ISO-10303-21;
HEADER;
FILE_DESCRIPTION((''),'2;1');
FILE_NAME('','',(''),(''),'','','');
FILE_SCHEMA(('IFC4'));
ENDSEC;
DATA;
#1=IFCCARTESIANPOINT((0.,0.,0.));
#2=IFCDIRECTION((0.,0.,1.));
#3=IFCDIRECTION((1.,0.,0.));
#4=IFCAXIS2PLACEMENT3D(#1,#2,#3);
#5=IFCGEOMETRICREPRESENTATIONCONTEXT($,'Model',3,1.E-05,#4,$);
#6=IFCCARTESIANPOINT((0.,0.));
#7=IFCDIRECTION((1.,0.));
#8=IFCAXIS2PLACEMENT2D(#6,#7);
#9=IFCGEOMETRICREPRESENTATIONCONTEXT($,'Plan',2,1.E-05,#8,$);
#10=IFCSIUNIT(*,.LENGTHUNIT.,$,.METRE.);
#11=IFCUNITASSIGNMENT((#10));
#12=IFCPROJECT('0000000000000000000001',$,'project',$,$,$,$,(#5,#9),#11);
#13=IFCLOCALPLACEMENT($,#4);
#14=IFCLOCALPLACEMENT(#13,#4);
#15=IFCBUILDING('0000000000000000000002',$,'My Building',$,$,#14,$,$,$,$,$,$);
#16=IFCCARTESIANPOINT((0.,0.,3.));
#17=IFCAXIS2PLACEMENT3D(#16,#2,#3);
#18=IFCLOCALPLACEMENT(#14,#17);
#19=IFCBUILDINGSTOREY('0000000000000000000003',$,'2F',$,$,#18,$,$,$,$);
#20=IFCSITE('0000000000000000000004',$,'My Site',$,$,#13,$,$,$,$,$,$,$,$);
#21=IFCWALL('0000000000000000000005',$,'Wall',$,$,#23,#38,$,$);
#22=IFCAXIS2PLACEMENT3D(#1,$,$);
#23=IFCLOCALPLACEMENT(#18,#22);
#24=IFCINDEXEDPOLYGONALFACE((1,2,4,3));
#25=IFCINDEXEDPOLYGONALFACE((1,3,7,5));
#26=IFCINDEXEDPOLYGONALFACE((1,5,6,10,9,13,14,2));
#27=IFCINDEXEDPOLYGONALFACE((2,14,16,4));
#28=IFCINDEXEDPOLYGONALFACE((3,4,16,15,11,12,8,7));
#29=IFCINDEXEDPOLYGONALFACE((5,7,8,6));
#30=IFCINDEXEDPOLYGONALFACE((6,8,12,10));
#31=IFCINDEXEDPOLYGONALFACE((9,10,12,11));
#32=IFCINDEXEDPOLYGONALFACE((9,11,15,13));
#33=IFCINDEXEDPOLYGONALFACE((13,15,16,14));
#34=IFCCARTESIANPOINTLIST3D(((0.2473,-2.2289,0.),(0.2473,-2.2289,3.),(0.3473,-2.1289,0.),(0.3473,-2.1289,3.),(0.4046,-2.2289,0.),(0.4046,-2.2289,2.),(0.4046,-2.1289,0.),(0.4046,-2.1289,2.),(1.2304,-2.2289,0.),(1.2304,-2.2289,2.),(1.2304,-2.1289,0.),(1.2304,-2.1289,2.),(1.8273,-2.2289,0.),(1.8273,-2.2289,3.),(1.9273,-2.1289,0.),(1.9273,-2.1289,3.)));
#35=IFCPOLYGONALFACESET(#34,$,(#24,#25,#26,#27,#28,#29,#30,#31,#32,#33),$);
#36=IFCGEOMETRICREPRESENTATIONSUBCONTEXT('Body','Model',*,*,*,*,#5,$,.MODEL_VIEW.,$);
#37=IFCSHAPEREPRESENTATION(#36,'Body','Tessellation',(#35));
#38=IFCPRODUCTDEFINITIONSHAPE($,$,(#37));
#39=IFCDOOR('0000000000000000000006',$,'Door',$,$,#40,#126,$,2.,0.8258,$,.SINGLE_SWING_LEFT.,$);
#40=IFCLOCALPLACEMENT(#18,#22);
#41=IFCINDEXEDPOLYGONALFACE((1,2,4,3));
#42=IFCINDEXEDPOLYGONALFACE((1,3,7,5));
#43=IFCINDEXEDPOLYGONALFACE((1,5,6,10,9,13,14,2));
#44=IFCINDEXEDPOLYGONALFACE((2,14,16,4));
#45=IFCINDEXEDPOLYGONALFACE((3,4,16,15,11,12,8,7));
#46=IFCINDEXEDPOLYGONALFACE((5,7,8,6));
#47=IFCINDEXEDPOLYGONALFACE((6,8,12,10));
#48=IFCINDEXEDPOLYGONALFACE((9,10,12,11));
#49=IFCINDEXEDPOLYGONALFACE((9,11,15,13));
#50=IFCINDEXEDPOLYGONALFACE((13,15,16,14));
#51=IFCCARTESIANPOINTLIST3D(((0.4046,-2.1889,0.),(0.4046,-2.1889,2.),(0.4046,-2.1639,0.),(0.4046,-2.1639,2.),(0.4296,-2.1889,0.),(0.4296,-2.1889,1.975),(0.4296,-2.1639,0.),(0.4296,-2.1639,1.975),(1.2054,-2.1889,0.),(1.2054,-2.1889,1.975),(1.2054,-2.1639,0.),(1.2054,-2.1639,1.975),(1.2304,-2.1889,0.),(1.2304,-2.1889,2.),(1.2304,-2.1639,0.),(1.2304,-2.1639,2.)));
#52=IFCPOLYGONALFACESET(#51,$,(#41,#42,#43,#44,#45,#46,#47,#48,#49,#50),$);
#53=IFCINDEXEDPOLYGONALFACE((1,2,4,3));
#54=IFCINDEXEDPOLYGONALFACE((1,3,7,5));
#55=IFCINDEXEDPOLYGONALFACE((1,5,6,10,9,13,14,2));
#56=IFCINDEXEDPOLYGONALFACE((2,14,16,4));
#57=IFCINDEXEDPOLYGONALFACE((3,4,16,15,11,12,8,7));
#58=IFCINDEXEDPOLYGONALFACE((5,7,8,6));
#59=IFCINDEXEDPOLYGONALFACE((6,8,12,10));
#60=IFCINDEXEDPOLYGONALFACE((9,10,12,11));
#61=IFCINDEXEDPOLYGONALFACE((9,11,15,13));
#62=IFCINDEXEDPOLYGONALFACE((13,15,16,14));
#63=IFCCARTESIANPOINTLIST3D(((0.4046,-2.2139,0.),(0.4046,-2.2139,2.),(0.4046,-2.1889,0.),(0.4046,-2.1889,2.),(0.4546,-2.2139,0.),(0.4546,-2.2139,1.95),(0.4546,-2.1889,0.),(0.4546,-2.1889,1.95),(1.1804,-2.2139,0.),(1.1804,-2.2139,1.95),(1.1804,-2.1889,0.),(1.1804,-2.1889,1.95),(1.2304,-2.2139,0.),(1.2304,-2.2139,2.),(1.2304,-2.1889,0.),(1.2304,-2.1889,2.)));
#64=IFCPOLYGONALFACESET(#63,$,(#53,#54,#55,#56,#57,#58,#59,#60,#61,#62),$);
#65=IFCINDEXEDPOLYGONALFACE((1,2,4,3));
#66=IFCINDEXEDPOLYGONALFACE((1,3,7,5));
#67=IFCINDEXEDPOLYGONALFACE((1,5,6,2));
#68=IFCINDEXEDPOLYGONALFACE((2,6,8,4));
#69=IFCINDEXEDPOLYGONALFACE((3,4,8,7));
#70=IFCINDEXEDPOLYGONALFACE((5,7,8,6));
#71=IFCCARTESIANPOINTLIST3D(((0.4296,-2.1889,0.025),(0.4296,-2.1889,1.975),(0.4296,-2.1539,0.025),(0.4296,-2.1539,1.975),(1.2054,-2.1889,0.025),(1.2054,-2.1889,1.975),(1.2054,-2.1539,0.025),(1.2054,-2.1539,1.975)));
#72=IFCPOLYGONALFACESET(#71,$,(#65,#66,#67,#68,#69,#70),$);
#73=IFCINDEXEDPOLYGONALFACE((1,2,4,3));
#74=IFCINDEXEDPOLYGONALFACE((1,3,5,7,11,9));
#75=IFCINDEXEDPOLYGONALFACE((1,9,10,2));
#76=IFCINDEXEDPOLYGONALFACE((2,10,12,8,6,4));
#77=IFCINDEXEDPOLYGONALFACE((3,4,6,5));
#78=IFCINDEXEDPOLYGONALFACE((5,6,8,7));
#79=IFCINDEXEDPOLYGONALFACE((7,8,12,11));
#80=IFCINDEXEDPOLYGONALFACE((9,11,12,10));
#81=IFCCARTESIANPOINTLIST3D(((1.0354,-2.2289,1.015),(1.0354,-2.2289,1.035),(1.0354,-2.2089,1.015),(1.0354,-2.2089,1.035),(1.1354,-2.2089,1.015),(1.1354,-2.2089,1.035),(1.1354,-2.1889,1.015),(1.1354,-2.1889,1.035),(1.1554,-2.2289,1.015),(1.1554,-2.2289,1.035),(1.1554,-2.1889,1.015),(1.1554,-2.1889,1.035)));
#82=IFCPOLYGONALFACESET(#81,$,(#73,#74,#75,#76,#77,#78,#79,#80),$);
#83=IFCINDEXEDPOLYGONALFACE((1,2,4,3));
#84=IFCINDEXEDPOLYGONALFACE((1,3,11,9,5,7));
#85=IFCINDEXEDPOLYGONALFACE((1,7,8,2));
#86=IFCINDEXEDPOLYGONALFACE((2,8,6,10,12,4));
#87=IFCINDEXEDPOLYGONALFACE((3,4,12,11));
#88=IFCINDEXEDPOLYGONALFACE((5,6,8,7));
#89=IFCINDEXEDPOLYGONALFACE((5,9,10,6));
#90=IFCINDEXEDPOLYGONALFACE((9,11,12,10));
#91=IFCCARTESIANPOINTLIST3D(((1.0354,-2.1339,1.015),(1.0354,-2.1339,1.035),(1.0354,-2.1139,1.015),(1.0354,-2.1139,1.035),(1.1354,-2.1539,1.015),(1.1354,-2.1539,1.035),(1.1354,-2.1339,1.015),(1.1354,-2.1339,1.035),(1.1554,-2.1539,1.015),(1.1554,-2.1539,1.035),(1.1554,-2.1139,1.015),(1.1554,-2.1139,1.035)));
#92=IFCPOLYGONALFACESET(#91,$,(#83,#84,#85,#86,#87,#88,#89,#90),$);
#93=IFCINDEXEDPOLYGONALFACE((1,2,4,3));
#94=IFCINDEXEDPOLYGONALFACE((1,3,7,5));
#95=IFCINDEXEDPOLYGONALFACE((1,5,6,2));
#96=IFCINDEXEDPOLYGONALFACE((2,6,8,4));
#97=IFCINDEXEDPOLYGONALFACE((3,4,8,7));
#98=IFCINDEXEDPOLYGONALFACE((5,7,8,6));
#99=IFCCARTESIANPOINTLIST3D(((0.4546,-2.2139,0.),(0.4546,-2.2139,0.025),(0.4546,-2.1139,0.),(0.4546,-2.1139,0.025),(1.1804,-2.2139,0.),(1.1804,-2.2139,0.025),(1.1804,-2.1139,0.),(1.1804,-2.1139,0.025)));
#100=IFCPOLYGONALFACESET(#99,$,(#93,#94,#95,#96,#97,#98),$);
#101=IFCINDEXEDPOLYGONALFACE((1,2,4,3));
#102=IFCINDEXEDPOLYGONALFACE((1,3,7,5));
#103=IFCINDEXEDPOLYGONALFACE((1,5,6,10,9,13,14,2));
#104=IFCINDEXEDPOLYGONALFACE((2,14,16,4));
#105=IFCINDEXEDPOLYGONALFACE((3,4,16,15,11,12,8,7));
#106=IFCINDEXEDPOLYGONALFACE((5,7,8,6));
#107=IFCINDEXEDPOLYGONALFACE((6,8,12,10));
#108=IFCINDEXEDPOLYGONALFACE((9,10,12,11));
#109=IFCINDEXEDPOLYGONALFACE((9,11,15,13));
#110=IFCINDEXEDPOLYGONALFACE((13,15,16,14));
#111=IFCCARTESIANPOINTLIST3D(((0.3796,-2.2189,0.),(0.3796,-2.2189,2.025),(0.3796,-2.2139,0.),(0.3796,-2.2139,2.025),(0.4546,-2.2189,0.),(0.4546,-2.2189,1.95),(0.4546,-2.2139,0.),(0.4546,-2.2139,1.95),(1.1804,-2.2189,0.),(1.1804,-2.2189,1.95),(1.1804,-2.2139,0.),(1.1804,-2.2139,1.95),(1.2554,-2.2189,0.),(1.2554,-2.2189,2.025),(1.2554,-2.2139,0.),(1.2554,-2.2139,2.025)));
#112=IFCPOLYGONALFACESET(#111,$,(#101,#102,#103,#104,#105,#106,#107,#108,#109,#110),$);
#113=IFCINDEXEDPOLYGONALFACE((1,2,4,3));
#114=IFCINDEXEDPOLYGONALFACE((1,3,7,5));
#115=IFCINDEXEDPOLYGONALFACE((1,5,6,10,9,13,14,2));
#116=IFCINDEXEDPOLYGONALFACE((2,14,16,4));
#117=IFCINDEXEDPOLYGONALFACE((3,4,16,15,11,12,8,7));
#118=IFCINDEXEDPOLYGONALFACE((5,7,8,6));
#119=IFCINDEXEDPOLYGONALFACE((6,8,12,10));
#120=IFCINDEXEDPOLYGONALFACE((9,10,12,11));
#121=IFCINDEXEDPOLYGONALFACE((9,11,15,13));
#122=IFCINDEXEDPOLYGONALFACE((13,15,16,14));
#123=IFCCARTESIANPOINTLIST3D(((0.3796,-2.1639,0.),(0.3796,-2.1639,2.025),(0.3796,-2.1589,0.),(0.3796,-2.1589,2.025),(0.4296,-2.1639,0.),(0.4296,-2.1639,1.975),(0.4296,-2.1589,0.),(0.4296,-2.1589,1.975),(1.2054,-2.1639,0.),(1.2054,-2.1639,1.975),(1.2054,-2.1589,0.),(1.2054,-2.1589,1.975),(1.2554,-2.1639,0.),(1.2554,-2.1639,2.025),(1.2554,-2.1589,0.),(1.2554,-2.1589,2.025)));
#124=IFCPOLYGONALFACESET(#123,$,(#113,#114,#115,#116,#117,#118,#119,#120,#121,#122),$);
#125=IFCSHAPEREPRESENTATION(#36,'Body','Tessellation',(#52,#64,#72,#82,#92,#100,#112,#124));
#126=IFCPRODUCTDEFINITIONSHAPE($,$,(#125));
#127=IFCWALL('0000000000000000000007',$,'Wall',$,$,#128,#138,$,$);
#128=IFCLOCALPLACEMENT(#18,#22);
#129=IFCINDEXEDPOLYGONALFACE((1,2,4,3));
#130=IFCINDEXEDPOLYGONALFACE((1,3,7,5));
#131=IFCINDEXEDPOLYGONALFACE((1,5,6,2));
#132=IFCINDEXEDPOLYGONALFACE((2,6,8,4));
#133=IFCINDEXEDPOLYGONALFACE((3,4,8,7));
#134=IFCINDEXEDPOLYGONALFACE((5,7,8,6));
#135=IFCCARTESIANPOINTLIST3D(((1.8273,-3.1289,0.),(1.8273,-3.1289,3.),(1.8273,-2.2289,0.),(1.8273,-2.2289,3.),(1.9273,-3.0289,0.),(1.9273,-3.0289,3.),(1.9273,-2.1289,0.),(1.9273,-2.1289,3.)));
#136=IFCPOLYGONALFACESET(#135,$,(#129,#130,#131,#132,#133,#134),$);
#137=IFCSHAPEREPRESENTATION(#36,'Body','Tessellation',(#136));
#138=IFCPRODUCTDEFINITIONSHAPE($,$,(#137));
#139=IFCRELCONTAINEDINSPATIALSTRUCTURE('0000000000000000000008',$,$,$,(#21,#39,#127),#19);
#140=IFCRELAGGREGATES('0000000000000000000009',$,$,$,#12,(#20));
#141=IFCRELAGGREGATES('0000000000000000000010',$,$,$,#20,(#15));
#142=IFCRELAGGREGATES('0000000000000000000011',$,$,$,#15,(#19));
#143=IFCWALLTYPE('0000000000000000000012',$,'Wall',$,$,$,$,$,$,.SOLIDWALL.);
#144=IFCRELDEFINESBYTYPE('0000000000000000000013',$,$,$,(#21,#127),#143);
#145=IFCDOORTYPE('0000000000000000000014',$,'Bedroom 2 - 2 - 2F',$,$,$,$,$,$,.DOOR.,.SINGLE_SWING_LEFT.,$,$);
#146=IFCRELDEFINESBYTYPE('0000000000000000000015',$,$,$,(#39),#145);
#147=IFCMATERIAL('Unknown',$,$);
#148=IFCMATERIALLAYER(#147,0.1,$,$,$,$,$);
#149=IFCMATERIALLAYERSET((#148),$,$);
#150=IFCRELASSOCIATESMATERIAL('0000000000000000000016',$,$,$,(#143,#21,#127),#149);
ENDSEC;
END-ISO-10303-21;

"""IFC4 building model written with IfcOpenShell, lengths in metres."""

from ifc_helpers import new_model, entity, si_unit, frame, origin_with_axes, origin_2d_with_axis, place, context, subcontext, project, spatial, line, indexed_curve, outline, extrude, shape, source, transform, mapped, material, layer, layer_set, layer_usage, type_object, type_shapes, element, fill, save


model = new_model("IFC4")

# Units and contexts
model_context = context("Model", 3, precision=1e-05, world=origin_with_axes())
plan_context = context("Plan", 2, precision=1e-05, world=origin_2d_with_axis())
body_context_1 = subcontext(model_context, "Body", "Model", "MODEL_VIEW")
body_context_2 = subcontext(plan_context, "Body", "Plan", "PLAN_VIEW")
ifc_project = project(units=[si_unit("LENGTHUNIT", "METRE")], contexts=[model_context, plan_context])

# Site, building, storey
site_placement = place(None, origin_with_axes())
site = spatial("IfcSite", under=ifc_project, at=site_placement, Name="My Site")
building_placement = place(site_placement, origin_with_axes())
building = spatial("IfcBuilding", under=site, at=building_placement, Name="My Building")
storey_placement = place(building_placement, frame((0.0, 0.0, 3.0), z_axis=(0.0, 0.0, 1.0), x_axis=(1.0, 0.0, 0.0)))
storey = spatial("IfcBuildingStorey", under=building, at=storey_placement, Name="2F")

# Shared definitions
ifc_material = material(Name="Unknown")

# Shared definitions
ifc_layer_1 = layer(ifc_material, 0.1)
ifc_layer_set_1 = layer_set([ifc_layer_1])
wall_type_1 = type_object("IfcWallType", Name="Wall", PredefinedType="SOLIDWALL", material=ifc_layer_set_1)

# Wall, opening, door
ifc_layer_usage_1 = layer_usage(ifc_layer_set_1, "AXIS2", "POSITIVE", 0.0)
wall_1_placement = place(storey_placement, frame((0.2473, -2.2289, 0.0), z_axis=(0.0, 0.0, 1.0), x_axis=(1.0, 0.0, 0.0)))
wall_1 = element("IfcWall", 1, at=wall_1_placement, inside=storey, type_object=wall_type_1, material=ifc_layer_usage_1, Name="Wall", context=body_context_1, shape_type="SweptSolid", body=[
    extrude(outline(indexed_curve([(0.0, 0.0), (0.1, 0.1), (1.68, 0.1), (1.58, 0.0)], segments=[line(1, 2, 3, 4, 1)])), origin_with_axes(), (0.0, 0.0, 1.0), 3.0),
])
shared_shape_1 = source(origin_with_axes(), body_context_1, "Body", "SweptSolid", [
    extrude(outline(indexed_curve([(0.0, 0.0), (0.8258, 0.0), (0.8258, 2.0), (0.0, 2.0)], segments=[line(1, 2, 3, 4, 1)])), frame((0.0, -0.6, 0.0), z_axis=(0.0, -1.0, 0.0), x_axis=(1.0, 0.0, 0.0)), (0.0, 0.0, -1.0), 1.2),
])
opening_1_placement = place(wall_1_placement, frame((0.1573, 0.015, 0.0), z_axis=(0.0, 0.0, 1.0), x_axis=(1.0, 0.0, 0.0)))
opening_1 = element("IfcOpeningElement", 2, at=opening_1_placement, cuts=wall_1, PredefinedType="OPENING", context=body_context_1, shape_type="MappedRepresentation", body=[
    mapped(shared_shape_1, transform((0.0, 0.0, 0.0), x_axis=(1.0, 0.0, 0.0), y_axis=(0.0, 1.0, 0.0), z_axis=(0.0, 0.0, 1.0), scale=1.0)),
])
door_type_1 = type_object("IfcDoorType", Name="Bedroom 2 - 2 - 2F", OperationType="SINGLE_SWING_LEFT", PredefinedType="DOOR")
shared_shape_2 = source(origin_with_axes(), body_context_1, "Body", "SweptSolid", [
    extrude(outline(indexed_curve([(0.0, 0.0), (0.0, 2.0), (0.8258, 2.0), (0.8258, 0.0), (0.8008, 0.0), (0.8008, 1.975), (0.025, 1.975), (0.025, 0.0)], segments=[line(1, 2, 3, 4, 5, 6, 7, 8, 1)])), frame((0.0, 0.025, 0.0), z_axis=(0.0, -1.0, 0.0), x_axis=(1.0, 0.0, 0.0)), (0.0, 0.0, -1.0), 0.025),
    extrude(outline(indexed_curve([(0.0, 0.0), (0.0, 2.0), (0.8258, 2.0), (0.8258, 0.0), (0.7758, 0.0), (0.7758, 1.95), (0.05, 1.95), (0.05, 0.0)], segments=[line(1, 2, 3, 4, 5, 6, 7, 8, 1)])), frame((0.0, 0.0, 0.0), z_axis=(0.0, -1.0, 0.0), x_axis=(1.0, 0.0, 0.0)), (0.0, 0.0, -1.0), 0.025),
    extrude(outline(indexed_curve([(0.0, 0.0), (0.7758, 0.0), (0.7758, 0.035), (0.0, 0.035)], segments=[line(1, 2, 3, 4, 1)])), frame((0.025, 0.025, 0.025), z_axis=(0.0, 0.0, 1.0), x_axis=(1.0, 0.0, 0.0)), (0.0, 0.0, 1.0), 1.95),
    extrude(outline(indexed_curve([(0.0, 0.0), (0.0, -0.04), (-0.12, -0.04), (-0.12, -0.02), (-0.02, -0.02), (-0.02, 0.0)], segments=[line(1, 2, 3, 4, 5, 6, 1)])), frame((0.7508, 0.025, 1.015), z_axis=(0.0, 0.0, 1.0), x_axis=(1.0, 0.0, 0.0)), (0.0, 0.0, 1.0), 0.02),
    extrude(outline(indexed_curve([(0.0, 0.0), (0.0, 0.04), (-0.12, 0.04), (-0.12, 0.02), (-0.02, 0.02), (-0.02, 0.0)], segments=[line(1, 2, 3, 4, 5, 6, 1)])), frame((0.7508, 0.06, 1.015), z_axis=(0.0, 0.0, 1.0), x_axis=(1.0, 0.0, 0.0)), (0.0, 0.0, 1.0), 0.02),
    extrude(outline(indexed_curve([(0.0, 0.0), (0.7258, 0.0), (0.7258, 0.1), (0.0, 0.1)], segments=[line(1, 2, 3, 4, 1)])), frame((0.05, 0.0, 0.0), z_axis=(0.0, 0.0, 1.0), x_axis=(1.0, 0.0, 0.0)), (0.0, 0.0, 1.0), 0.025),
    extrude(outline(indexed_curve([(0.0, 0.0), (0.0, 2.025), (0.8758, 2.025), (0.8758, 0.0), (0.8008, 0.0), (0.8008, 1.95), (0.075, 1.95), (0.075, 0.0)], segments=[line(1, 2, 3, 4, 5, 6, 7, 8, 1)])), frame((-0.025, -0.005, 0.0), z_axis=(0.0, -1.0, 0.0), x_axis=(1.0, 0.0, 0.0)), (0.0, 0.0, -1.0), 0.005),
    extrude(outline(indexed_curve([(0.0, 0.0), (0.0, 2.025), (0.8758, 2.025), (0.8758, 0.0), (0.8258, 0.0), (0.8258, 1.975), (0.05, 1.975), (0.05, 0.0)], segments=[line(1, 2, 3, 4, 5, 6, 7, 8, 1)])), frame((-0.025, 0.05, 0.0), z_axis=(0.0, -1.0, 0.0), x_axis=(1.0, 0.0, 0.0)), (0.0, 0.0, -1.0), 0.005),
])
shared_shape_3 = source(origin_with_axes(), body_context_2, "Body", "Curve2D", [
    entity("IfcIndexedPolyCurve", entity("IfcCartesianPointList2D", [[0.0, 0.0], [0.0, 0.05], [0.025, 0.05], [0.025, 0.025], [0.05, 0.025], [0.05, 0.0]]), [entity("IfcLineIndex", [1, 2, 3, 4, 5, 6, 1])]),
    entity("IfcIndexedPolyCurve", entity("IfcCartesianPointList2D", [[0.8258, 0.0], [0.8258, 0.05], [0.8008, 0.05], [0.8008, 0.025], [0.7758, 0.025], [0.7758, 0.0]]), [entity("IfcLineIndex", [1, 2, 3, 4, 5, 6, 1])]),
    entity("IfcTrimmedCurve", entity("IfcEllipse", entity("IfcAxis2Placement2D", entity("IfcCartesianPoint", [0.06, 0.05]), entity("IfcDirection", [1.0, 0.0])), 0.7408, 0.7758), [entity("IfcCartesianPoint", [0.8008, 0.05])], [entity("IfcCartesianPoint", [0.06, 0.8258])], True, "CARTESIAN"),
    entity("IfcIndexedPolyCurve", entity("IfcCartesianPointList2D", [[0.025, 0.05], [0.06, 0.05], [0.06, 0.8258], [0.025, 0.8258]]), [entity("IfcLineIndex", [1, 2, 3, 4, 1])]),
])
type_shapes(door_type_1, [shared_shape_2, shared_shape_3])
door_1_placement = place(opening_1_placement, frame((0.0, 0.0, 0.0), z_axis=(0.0, 0.0, 1.0), x_axis=(1.0, 0.0, 0.0)))
door_1 = element("IfcDoor", 3, at=door_1_placement, inside=storey, type_object=door_type_1, Name="Door", OperationType="SINGLE_SWING_LEFT", OverallHeight=2.0, OverallWidth=0.8258, shapes=[
    shape(body_context_1, "Body", "MappedRepresentation", [mapped(shared_shape_2, transform((0.0, 0.0, 0.0), x_axis=(1.0, 0.0, 0.0), y_axis=(0.0, 1.0, 0.0), z_axis=(0.0, 0.0, 1.0), scale=1.0))]),
    shape(body_context_2, "Body", "MappedRepresentation", [mapped(shared_shape_3, transform((0.0, 0.0, 0.0), x_axis=(1.0, 0.0, 0.0), y_axis=(0.0, 1.0, 0.0), z_axis=(0.0, 0.0, 1.0), scale=1.0))]),
])
fill(opening_1, door_1)

# Wall
ifc_layer_usage_2 = layer_usage(ifc_layer_set_1, "AXIS2", "POSITIVE", 0.0)
wall_2_placement = place(storey_placement, frame((1.8273, -2.2289, 0.0), z_axis=(0.0, 0.0, 1.0), x_axis=(0.0, -1.0, 0.0)))
element("IfcWall", 4, at=wall_2_placement, inside=storey, type_object=wall_type_1, material=ifc_layer_usage_2, Name="Wall", context=body_context_1, shape_type="SweptSolid", body=[
    extrude(outline(indexed_curve([(0.0, 0.0), (-0.1, 0.1), (0.8, 0.1), (0.9, 0.0)], segments=[line(1, 2, 3, 4, 1)])), origin_with_axes(), (0.0, 0.0, 1.0), 3.0),
])

save(model, "model.ifc")
